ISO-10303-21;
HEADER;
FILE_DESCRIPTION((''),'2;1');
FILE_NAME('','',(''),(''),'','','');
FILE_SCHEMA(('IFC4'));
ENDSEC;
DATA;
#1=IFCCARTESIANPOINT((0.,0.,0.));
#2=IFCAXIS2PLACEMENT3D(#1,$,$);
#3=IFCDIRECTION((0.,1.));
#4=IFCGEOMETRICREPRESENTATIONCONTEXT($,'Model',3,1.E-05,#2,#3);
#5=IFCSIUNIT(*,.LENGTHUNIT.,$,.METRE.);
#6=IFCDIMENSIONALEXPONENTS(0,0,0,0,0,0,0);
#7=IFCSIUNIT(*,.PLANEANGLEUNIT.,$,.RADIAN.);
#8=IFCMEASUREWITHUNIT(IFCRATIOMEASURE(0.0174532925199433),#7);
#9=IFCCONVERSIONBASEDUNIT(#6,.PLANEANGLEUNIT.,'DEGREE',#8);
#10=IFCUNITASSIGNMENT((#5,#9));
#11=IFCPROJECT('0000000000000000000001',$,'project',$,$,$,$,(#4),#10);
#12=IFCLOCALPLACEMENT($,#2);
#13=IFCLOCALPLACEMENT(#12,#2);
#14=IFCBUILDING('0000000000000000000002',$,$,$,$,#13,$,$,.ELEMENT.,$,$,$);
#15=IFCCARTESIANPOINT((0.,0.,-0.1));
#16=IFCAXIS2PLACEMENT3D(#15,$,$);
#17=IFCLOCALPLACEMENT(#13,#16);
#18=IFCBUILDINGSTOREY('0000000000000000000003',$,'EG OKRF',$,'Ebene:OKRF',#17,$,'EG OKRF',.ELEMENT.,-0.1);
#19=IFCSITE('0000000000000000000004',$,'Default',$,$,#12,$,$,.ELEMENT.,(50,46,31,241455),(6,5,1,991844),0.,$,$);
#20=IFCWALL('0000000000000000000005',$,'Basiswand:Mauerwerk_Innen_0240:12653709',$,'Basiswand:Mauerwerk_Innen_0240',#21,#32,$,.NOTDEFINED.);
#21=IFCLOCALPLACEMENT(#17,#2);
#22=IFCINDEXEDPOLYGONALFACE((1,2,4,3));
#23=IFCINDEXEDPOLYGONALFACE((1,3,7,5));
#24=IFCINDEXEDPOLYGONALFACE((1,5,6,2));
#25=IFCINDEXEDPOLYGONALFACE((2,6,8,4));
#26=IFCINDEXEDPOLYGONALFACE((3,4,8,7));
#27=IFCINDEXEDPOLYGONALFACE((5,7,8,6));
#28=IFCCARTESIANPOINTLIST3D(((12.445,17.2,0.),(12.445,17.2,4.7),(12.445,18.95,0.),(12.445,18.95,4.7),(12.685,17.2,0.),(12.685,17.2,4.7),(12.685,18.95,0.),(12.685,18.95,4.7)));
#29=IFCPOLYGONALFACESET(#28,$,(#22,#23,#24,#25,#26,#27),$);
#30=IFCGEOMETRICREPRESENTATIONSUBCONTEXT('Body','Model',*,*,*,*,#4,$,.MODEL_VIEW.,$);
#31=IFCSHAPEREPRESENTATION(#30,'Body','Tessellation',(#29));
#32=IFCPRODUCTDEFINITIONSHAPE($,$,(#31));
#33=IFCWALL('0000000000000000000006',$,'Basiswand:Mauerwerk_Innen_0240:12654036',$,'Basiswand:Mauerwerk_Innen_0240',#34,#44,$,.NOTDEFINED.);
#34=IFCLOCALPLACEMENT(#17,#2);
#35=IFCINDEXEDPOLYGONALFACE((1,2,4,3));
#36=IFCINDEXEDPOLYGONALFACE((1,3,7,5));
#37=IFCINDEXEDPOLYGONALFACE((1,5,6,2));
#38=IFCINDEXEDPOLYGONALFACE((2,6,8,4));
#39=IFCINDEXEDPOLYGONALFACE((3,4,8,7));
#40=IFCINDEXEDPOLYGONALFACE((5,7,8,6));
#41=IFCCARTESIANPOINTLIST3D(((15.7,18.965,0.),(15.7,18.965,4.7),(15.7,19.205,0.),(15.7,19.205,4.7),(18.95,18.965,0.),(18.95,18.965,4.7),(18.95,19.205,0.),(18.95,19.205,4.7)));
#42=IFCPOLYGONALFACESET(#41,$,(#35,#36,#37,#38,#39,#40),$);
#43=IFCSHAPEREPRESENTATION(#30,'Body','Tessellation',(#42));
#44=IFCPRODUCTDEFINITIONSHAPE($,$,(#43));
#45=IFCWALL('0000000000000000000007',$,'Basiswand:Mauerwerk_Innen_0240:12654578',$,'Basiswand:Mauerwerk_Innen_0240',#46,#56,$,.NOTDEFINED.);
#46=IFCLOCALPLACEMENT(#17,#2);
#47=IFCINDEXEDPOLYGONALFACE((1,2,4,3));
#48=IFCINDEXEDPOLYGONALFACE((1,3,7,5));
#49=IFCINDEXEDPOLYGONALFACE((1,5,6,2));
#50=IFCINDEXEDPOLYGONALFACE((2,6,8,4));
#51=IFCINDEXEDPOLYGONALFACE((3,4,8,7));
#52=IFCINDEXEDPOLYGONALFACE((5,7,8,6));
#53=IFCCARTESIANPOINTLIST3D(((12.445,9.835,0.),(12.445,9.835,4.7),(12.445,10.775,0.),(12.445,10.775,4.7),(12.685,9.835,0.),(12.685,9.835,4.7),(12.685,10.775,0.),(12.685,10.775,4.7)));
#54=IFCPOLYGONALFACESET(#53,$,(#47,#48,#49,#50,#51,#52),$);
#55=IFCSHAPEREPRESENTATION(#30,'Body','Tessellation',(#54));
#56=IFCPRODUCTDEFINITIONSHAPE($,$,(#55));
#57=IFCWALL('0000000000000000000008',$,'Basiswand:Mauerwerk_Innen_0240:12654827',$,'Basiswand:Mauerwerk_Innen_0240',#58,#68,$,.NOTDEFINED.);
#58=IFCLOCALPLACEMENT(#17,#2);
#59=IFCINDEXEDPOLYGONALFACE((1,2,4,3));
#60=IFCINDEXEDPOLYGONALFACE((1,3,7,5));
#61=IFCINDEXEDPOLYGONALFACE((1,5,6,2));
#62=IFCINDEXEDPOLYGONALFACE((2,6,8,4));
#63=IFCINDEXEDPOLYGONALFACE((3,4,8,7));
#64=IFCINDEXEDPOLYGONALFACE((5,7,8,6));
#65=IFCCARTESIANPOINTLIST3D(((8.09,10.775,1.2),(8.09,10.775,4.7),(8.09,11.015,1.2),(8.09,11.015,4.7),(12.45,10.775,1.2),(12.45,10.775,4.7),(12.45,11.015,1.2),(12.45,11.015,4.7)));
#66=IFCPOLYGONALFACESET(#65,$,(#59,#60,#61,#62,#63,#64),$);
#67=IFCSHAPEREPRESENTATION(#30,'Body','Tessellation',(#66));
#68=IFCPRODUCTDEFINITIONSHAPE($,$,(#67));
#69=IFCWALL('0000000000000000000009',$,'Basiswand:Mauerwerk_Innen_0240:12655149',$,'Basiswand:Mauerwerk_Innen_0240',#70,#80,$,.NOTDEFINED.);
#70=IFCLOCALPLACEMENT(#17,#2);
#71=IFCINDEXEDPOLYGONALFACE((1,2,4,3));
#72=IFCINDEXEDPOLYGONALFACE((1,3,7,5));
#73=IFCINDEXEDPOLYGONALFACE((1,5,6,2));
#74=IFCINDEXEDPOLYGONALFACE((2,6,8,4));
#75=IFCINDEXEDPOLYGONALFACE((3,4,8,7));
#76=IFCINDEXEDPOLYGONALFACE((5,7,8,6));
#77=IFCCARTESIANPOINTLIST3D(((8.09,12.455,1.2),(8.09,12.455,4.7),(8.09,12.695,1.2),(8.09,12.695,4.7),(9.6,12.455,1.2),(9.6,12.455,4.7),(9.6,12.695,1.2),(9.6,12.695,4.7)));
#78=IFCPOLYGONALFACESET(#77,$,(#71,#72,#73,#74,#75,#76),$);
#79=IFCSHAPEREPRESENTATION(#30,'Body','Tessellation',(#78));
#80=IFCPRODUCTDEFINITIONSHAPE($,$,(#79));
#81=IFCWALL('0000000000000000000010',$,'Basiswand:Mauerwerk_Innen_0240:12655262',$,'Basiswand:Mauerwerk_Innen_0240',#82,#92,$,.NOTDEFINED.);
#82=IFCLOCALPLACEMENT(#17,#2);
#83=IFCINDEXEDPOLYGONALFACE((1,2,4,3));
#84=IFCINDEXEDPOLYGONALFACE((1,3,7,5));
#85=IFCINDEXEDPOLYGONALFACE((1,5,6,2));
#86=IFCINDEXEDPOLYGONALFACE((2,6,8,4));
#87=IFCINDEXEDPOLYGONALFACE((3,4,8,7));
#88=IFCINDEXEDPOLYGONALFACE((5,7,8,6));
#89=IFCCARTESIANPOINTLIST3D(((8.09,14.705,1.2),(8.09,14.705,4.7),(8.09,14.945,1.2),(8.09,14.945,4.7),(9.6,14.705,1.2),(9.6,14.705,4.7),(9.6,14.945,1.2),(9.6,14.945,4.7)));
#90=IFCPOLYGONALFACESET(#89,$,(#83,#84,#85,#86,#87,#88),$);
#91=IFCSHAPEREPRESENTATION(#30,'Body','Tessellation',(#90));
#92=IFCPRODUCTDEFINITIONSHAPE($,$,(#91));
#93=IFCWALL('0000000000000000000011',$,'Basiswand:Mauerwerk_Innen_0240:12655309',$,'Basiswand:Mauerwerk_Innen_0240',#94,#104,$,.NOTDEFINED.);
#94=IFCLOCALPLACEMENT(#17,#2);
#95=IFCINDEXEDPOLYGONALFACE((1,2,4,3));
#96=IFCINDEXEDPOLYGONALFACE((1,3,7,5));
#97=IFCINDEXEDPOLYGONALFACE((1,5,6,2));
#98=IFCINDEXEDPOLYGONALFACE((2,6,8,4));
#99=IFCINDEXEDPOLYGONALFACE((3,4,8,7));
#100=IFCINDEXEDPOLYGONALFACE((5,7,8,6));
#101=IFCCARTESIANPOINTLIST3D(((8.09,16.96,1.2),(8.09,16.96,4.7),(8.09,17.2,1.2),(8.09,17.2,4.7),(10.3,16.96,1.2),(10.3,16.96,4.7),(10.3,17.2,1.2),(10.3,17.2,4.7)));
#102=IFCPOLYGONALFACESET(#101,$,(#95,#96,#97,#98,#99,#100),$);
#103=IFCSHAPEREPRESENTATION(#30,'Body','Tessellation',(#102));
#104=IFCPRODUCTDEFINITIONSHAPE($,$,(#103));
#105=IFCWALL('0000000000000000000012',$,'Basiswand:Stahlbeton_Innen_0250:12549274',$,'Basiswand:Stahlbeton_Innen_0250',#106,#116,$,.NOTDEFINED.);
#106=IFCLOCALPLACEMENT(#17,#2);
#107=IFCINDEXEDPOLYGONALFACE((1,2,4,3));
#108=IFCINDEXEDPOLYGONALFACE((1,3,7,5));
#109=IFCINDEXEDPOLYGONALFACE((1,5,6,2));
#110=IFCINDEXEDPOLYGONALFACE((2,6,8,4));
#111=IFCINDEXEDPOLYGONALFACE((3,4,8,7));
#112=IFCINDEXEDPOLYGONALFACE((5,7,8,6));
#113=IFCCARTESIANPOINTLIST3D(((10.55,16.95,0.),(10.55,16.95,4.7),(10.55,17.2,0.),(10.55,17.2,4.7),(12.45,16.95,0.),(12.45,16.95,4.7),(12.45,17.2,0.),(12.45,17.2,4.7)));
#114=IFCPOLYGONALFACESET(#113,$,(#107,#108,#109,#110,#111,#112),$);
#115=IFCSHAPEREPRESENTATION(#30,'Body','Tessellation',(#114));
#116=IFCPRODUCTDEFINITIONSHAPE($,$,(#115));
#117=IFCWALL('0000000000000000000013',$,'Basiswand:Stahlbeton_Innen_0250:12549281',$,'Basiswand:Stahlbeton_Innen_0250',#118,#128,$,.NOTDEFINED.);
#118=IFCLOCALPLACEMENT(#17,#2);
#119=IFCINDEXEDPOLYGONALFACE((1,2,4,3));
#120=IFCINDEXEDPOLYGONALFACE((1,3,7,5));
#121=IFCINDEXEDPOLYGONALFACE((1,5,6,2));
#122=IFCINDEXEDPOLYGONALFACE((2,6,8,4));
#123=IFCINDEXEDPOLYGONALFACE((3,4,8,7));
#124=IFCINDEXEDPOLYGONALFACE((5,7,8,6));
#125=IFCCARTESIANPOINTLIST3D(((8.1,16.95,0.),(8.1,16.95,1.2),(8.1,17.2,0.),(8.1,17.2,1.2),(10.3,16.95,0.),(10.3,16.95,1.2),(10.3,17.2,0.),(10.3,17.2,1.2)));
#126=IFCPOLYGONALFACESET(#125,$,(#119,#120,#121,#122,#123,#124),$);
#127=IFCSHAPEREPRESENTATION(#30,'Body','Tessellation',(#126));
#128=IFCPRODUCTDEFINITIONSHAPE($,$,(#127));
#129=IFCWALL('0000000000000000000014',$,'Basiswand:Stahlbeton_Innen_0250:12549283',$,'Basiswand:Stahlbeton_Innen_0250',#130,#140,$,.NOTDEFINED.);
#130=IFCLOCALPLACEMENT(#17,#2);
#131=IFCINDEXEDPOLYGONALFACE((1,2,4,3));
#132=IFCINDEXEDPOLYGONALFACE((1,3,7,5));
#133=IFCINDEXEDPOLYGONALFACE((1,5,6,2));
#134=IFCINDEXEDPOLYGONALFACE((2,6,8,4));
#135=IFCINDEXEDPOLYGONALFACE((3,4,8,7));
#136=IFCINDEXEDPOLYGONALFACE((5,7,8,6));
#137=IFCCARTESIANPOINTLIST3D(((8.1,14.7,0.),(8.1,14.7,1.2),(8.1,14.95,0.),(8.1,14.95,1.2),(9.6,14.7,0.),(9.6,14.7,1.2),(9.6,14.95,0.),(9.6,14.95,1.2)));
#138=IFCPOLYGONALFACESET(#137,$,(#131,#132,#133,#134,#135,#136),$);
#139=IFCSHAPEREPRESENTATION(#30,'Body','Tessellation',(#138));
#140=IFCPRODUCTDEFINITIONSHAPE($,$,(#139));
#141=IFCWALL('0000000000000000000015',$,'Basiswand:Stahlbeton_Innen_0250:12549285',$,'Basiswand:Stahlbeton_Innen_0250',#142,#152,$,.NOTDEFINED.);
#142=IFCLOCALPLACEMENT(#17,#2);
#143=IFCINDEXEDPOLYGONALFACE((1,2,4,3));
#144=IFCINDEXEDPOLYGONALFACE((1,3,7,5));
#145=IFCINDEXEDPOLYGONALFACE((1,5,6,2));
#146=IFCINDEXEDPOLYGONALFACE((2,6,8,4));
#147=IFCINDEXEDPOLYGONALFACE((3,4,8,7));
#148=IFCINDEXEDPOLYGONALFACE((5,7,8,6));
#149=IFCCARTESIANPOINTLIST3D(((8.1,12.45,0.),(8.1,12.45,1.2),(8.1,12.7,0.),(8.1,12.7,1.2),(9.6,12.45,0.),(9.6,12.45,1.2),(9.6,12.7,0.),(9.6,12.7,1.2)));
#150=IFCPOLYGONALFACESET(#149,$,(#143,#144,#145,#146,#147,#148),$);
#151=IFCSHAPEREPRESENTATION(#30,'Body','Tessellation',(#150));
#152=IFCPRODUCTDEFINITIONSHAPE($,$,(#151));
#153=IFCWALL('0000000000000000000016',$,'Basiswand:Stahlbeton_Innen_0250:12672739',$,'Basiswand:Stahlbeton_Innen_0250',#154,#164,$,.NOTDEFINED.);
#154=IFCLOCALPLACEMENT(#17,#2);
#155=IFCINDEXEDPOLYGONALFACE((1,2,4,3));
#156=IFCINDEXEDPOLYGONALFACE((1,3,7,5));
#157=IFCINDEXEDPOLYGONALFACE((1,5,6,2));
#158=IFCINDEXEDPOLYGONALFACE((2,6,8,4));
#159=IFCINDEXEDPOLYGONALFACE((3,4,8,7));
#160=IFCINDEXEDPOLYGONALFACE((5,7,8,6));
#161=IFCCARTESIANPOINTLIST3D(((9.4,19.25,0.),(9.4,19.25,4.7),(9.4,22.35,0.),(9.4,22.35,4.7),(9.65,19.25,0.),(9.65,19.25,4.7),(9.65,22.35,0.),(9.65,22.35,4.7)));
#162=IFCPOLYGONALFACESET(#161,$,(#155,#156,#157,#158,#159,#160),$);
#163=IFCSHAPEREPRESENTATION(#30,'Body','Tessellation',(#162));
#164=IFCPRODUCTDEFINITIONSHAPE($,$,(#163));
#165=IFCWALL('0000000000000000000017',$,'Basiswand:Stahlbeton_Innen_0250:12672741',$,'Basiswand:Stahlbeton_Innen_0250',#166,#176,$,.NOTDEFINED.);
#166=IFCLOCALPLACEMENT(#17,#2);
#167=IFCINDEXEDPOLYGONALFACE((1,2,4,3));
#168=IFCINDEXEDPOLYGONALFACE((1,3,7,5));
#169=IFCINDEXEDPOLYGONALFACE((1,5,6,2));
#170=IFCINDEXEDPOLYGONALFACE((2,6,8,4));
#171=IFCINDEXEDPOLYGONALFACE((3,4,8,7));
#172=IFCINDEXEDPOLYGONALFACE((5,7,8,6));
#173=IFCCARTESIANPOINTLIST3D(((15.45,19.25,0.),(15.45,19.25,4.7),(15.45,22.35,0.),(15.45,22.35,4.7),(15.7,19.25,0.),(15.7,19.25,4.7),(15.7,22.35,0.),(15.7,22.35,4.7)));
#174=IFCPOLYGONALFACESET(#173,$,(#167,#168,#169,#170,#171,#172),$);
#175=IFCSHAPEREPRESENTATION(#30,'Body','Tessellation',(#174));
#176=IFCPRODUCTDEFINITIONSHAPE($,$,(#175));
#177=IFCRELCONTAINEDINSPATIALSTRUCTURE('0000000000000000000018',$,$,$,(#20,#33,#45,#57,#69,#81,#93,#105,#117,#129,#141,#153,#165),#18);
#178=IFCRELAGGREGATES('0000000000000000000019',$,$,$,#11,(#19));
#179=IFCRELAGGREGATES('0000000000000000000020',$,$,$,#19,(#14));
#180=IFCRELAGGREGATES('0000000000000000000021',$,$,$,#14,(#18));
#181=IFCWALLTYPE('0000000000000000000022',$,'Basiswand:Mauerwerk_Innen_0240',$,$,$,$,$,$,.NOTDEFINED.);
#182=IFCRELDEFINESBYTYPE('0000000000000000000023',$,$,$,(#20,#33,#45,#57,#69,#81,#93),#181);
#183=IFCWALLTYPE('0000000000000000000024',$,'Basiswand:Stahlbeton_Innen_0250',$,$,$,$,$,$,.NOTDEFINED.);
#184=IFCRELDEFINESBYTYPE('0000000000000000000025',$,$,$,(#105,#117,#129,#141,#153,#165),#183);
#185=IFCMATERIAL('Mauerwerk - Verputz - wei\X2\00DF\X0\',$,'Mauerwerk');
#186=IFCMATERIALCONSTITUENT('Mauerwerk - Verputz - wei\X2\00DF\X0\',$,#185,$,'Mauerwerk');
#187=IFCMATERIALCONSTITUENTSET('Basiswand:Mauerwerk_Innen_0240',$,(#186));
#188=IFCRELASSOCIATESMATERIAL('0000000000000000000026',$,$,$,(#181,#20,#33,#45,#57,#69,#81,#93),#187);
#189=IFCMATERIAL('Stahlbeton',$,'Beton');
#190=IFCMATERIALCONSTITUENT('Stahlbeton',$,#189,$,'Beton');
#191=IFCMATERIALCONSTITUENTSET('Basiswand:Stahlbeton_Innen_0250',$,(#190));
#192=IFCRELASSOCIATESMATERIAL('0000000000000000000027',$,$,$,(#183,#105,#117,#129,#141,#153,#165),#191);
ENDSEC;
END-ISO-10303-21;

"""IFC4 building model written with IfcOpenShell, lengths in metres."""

from ifc_helpers import new_model, entity, si_unit, converted_unit, direction, frame, origin, place, context, subcontext, project, spatial, indexed_curve, outline, extrude, material, constituent, constituent_set, type_object, element, save


model = new_model("IFC4")

# Units and contexts
model_context = context("Model", 3, precision=1e-05, world=origin(), true_north=direction((0.0, 1.0)))
body_context = subcontext(model_context, "Body", "Model", "MODEL_VIEW")
ifc_project = project(units=[si_unit("LENGTHUNIT", "METRE"), converted_unit("PLANEANGLEUNIT", "DEGREE", entity("IfcRatioMeasure", 0.0174532925199433), si_unit("PLANEANGLEUNIT", "RADIAN"), dimensions=[0, 0, 0, 0, 0, 0, 0])], contexts=[model_context])

# Site, building, storey
site_placement = place(None, origin())
site = spatial("IfcSite", under=ifc_project, at=site_placement, Name="Default", CompositionType="ELEMENT", RefLatitude=(50, 46, 31, 241455), RefLongitude=(6, 5, 1, 991844), RefElevation=0.0)
building_placement = place(site_placement, origin())
building = spatial("IfcBuilding", under=site, at=building_placement, CompositionType="ELEMENT")
storey_placement = place(building_placement, frame((0.0, 0.0, -0.1)))
storey = spatial("IfcBuildingStorey", under=building, at=storey_placement, Name="EG OKRF", ObjectType="Ebene:OKRF", LongName="EG OKRF", CompositionType="ELEMENT", Elevation=-0.1)

# Walls
ifc_material_1 = material(Name="Mauerwerk - Verputz - weiß", Category="Mauerwerk")
ifc_constituent_1 = constituent(ifc_material_1, Name="Mauerwerk - Verputz - weiß", Category="Mauerwerk")
ifc_constituent_set_1 = constituent_set(constituents=[ifc_constituent_1], Name="Basiswand:Mauerwerk_Innen_0240")
wall_type_1 = type_object("IfcWallType", Name="Basiswand:Mauerwerk_Innen_0240", PredefinedType="NOTDEFINED", material=ifc_constituent_set_1)
wall_1_placement = place(storey_placement, frame((12.565, 17.2, 0.0), z_axis=(0.0, 0.0, 1.0), x_axis=(0.0, 1.0, 0.0)))
element("IfcWall", 1, at=wall_1_placement, inside=storey, type_object=wall_type_1, material=ifc_constituent_set_1, Name="Basiswand:Mauerwerk_Innen_0240:12653709", ObjectType="Basiswand:Mauerwerk_Innen_0240", PredefinedType="NOTDEFINED", context=body_context, shape_type="SweptSolid", body=[
    extrude(outline(indexed_curve([(-0.12, -0.875), (0.12, -0.875), (0.12, 0.875), (-0.12, 0.875), (-0.12, -0.875)], self_intersect=False)), frame((0.875, 0.0, 0.0), z_axis=(0.0, 0.0, 1.0), x_axis=(0.0, 1.0, 0.0)), (0.0, 0.0, 1.0), 4.7),
])
wall_2_placement = place(storey_placement, frame((15.7, 19.085, 0.0)))
element("IfcWall", 2, at=wall_2_placement, inside=storey, type_object=wall_type_1, material=ifc_constituent_set_1, Name="Basiswand:Mauerwerk_Innen_0240:12654036", ObjectType="Basiswand:Mauerwerk_Innen_0240", PredefinedType="NOTDEFINED", context=body_context, shape_type="SweptSolid", body=[
    extrude(outline(indexed_curve([(-0.12, -1.625), (0.12, -1.625), (0.12, 1.625), (-0.12, 1.625), (-0.12, -1.625)], self_intersect=False)), frame((1.625, 0.0, 0.0), z_axis=(0.0, 0.0, 1.0), x_axis=(0.0, 1.0, 0.0)), (0.0, 0.0, 1.0), 4.7),
])
wall_3_placement = place(storey_placement, frame((12.565, 9.835, 0.0), z_axis=(0.0, 0.0, 1.0), x_axis=(0.0, 1.0, 0.0)))
element("IfcWall", 3, at=wall_3_placement, inside=storey, type_object=wall_type_1, material=ifc_constituent_set_1, Name="Basiswand:Mauerwerk_Innen_0240:12654578", ObjectType="Basiswand:Mauerwerk_Innen_0240", PredefinedType="NOTDEFINED", context=body_context, shape_type="SweptSolid", body=[
    extrude(outline(indexed_curve([(-0.12, -0.47), (0.12, -0.47), (0.12, 0.47), (-0.12, 0.47), (-0.12, -0.47)], self_intersect=False)), frame((0.47, 0.0, 0.0), z_axis=(0.0, 0.0, 1.0), x_axis=(0.0, 1.0, 0.0)), (0.0, 0.0, 1.0), 4.7),
])
wall_4_placement = place(storey_placement, frame((12.45, 10.895, 1.2), z_axis=(0.0, 0.0, 1.0), x_axis=(-1.0, 0.0, 0.0)))
element("IfcWall", 4, at=wall_4_placement, inside=storey, type_object=wall_type_1, material=ifc_constituent_set_1, Name="Basiswand:Mauerwerk_Innen_0240:12654827", ObjectType="Basiswand:Mauerwerk_Innen_0240", PredefinedType="NOTDEFINED", context=body_context, shape_type="SweptSolid", body=[
    extrude(outline(indexed_curve([(-0.12, -2.18), (0.12, -2.18), (0.12, 2.18), (-0.12, 2.18), (-0.12, -2.18)], self_intersect=False)), frame((2.18, 0.0, 0.0), z_axis=(0.0, 0.0, 1.0), x_axis=(0.0, 1.0, 0.0)), (0.0, 0.0, 1.0), 3.5),
])
wall_5_placement = place(storey_placement, frame((9.6, 12.575, 1.2), z_axis=(0.0, 0.0, 1.0), x_axis=(-1.0, 0.0, 0.0)))
element("IfcWall", 5, at=wall_5_placement, inside=storey, type_object=wall_type_1, material=ifc_constituent_set_1, Name="Basiswand:Mauerwerk_Innen_0240:12655149", ObjectType="Basiswand:Mauerwerk_Innen_0240", PredefinedType="NOTDEFINED", context=body_context, shape_type="SweptSolid", body=[
    extrude(outline(indexed_curve([(-0.12, -0.755), (0.12, -0.755), (0.12, 0.755), (-0.12, 0.755), (-0.12, -0.755)], self_intersect=False)), frame((0.755, 0.0, 0.0), z_axis=(0.0, 0.0, 1.0), x_axis=(0.0, 1.0, 0.0)), (0.0, 0.0, 1.0), 3.5),
])
wall_6_placement = place(storey_placement, frame((9.6, 14.825, 1.2), z_axis=(0.0, 0.0, 1.0), x_axis=(-1.0, 0.0, 0.0)))
element("IfcWall", 6, at=wall_6_placement, inside=storey, type_object=wall_type_1, material=ifc_constituent_set_1, Name="Basiswand:Mauerwerk_Innen_0240:12655262", ObjectType="Basiswand:Mauerwerk_Innen_0240", PredefinedType="NOTDEFINED", context=body_context, shape_type="SweptSolid", body=[
    extrude(outline(indexed_curve([(-0.12, -0.755), (0.12, -0.755), (0.12, 0.755), (-0.12, 0.755), (-0.12, -0.755)], self_intersect=False)), frame((0.755, 0.0, 0.0), z_axis=(0.0, 0.0, 1.0), x_axis=(0.0, 1.0, 0.0)), (0.0, 0.0, 1.0), 3.5),
])
wall_7_placement = place(storey_placement, frame((10.3, 17.08, 1.2), z_axis=(0.0, 0.0, 1.0), x_axis=(-1.0, 0.0, 0.0)))
element("IfcWall", 7, at=wall_7_placement, inside=storey, type_object=wall_type_1, material=ifc_constituent_set_1, Name="Basiswand:Mauerwerk_Innen_0240:12655309", ObjectType="Basiswand:Mauerwerk_Innen_0240", PredefinedType="NOTDEFINED", context=body_context, shape_type="SweptSolid", body=[
    extrude(outline(indexed_curve([(-0.12, -1.105), (0.12, -1.105), (0.12, 1.105), (-0.12, 1.105), (-0.12, -1.105)], self_intersect=False)), frame((1.105, 0.0, 0.0), z_axis=(0.0, 0.0, 1.0), x_axis=(0.0, 1.0, 0.0)), (0.0, 0.0, 1.0), 3.5),
])
ifc_material_2 = material(Name="Stahlbeton", Category="Beton")
ifc_constituent_2 = constituent(ifc_material_2, Name="Stahlbeton", Category="Beton")
ifc_constituent_set_2 = constituent_set(constituents=[ifc_constituent_2], Name="Basiswand:Stahlbeton_Innen_0250")
wall_type_2 = type_object("IfcWallType", Name="Basiswand:Stahlbeton_Innen_0250", PredefinedType="NOTDEFINED", material=ifc_constituent_set_2)
wall_8_placement = place(storey_placement, frame((12.45, 17.075, 0.0), z_axis=(0.0, 0.0, 1.0), x_axis=(-1.0, 0.0, 0.0)))
element("IfcWall", 8, at=wall_8_placement, inside=storey, type_object=wall_type_2, material=ifc_constituent_set_2, Name="Basiswand:Stahlbeton_Innen_0250:12549274", ObjectType="Basiswand:Stahlbeton_Innen_0250", PredefinedType="NOTDEFINED", context=body_context, shape_type="SweptSolid", body=[
    extrude(outline(indexed_curve([(-0.125, -0.95), (0.125, -0.95), (0.125, 0.95), (-0.125, 0.95), (-0.125, -0.95)], self_intersect=False)), frame((0.95, 0.0, 0.0), z_axis=(0.0, 0.0, 1.0), x_axis=(0.0, 1.0, 0.0)), (0.0, 0.0, 1.0), 4.7),
])
wall_9_placement = place(storey_placement, frame((8.1, 17.075, 0.0)))
element("IfcWall", 9, at=wall_9_placement, inside=storey, type_object=wall_type_2, material=ifc_constituent_set_2, Name="Basiswand:Stahlbeton_Innen_0250:12549281", ObjectType="Basiswand:Stahlbeton_Innen_0250", PredefinedType="NOTDEFINED", context=body_context, shape_type="SweptSolid", body=[
    extrude(outline(indexed_curve([(-0.125, -1.1), (0.125, -1.1), (0.125, 1.1), (-0.125, 1.1), (-0.125, -1.1)], self_intersect=False)), frame((1.1, 0.0, 0.0), z_axis=(0.0, 0.0, 1.0), x_axis=(0.0, 1.0, 0.0)), (0.0, 0.0, 1.0), 1.2),
])
wall_10_placement = place(storey_placement, frame((8.1, 14.825, 0.0)))
element("IfcWall", 10, at=wall_10_placement, inside=storey, type_object=wall_type_2, material=ifc_constituent_set_2, Name="Basiswand:Stahlbeton_Innen_0250:12549283", ObjectType="Basiswand:Stahlbeton_Innen_0250", PredefinedType="NOTDEFINED", context=body_context, shape_type="SweptSolid", body=[
    extrude(outline(indexed_curve([(-0.125, -0.75), (0.125, -0.75), (0.125, 0.75), (-0.125, 0.75), (-0.125, -0.75)], self_intersect=False)), frame((0.75, 0.0, 0.0), z_axis=(0.0, 0.0, 1.0), x_axis=(0.0, 1.0, 0.0)), (0.0, 0.0, 1.0), 1.2),
])
wall_11_placement = place(storey_placement, frame((8.1, 12.575, 0.0)))
element("IfcWall", 11, at=wall_11_placement, inside=storey, type_object=wall_type_2, material=ifc_constituent_set_2, Name="Basiswand:Stahlbeton_Innen_0250:12549285", ObjectType="Basiswand:Stahlbeton_Innen_0250", PredefinedType="NOTDEFINED", context=body_context, shape_type="SweptSolid", body=[
    extrude(outline(indexed_curve([(-0.125, -0.75), (0.125, -0.75), (0.125, 0.75), (-0.125, 0.75), (-0.125, -0.75)], self_intersect=False)), frame((0.75, 0.0, 0.0), z_axis=(0.0, 0.0, 1.0), x_axis=(0.0, 1.0, 0.0)), (0.0, 0.0, 1.0), 1.2),
])
wall_12_placement = place(storey_placement, frame((9.525, 22.35, 0.0), z_axis=(0.0, 0.0, 1.0), x_axis=(0.0, -1.0, 0.0)))
element("IfcWall", 12, at=wall_12_placement, inside=storey, type_object=wall_type_2, material=ifc_constituent_set_2, Name="Basiswand:Stahlbeton_Innen_0250:12672739", ObjectType="Basiswand:Stahlbeton_Innen_0250", PredefinedType="NOTDEFINED", context=body_context, shape_type="SweptSolid", body=[
    extrude(outline(indexed_curve([(-0.125, -1.55), (0.125, -1.55), (0.125, 1.55), (-0.125, 1.55), (-0.125, -1.55)], self_intersect=False)), frame((1.55, 0.0, 0.0), z_axis=(0.0, 0.0, 1.0), x_axis=(0.0, 1.0, 0.0)), (0.0, 0.0, 1.0), 4.7),
])
wall_13_placement = place(storey_placement, frame((15.575, 22.35, 0.0), z_axis=(0.0, 0.0, 1.0), x_axis=(0.0, -1.0, 0.0)))
element("IfcWall", 13, at=wall_13_placement, inside=storey, type_object=wall_type_2, material=ifc_constituent_set_2, Name="Basiswand:Stahlbeton_Innen_0250:12672741", ObjectType="Basiswand:Stahlbeton_Innen_0250", PredefinedType="NOTDEFINED", context=body_context, shape_type="SweptSolid", body=[
    extrude(outline(indexed_curve([(-0.125, -1.55), (0.125, -1.55), (0.125, 1.55), (-0.125, 1.55), (-0.125, -1.55)], self_intersect=False)), frame((1.55, 0.0, 0.0), z_axis=(0.0, 0.0, 1.0), x_axis=(0.0, 1.0, 0.0)), (0.0, 0.0, 1.0), 4.7),
])

save(model, "model.ifc")
